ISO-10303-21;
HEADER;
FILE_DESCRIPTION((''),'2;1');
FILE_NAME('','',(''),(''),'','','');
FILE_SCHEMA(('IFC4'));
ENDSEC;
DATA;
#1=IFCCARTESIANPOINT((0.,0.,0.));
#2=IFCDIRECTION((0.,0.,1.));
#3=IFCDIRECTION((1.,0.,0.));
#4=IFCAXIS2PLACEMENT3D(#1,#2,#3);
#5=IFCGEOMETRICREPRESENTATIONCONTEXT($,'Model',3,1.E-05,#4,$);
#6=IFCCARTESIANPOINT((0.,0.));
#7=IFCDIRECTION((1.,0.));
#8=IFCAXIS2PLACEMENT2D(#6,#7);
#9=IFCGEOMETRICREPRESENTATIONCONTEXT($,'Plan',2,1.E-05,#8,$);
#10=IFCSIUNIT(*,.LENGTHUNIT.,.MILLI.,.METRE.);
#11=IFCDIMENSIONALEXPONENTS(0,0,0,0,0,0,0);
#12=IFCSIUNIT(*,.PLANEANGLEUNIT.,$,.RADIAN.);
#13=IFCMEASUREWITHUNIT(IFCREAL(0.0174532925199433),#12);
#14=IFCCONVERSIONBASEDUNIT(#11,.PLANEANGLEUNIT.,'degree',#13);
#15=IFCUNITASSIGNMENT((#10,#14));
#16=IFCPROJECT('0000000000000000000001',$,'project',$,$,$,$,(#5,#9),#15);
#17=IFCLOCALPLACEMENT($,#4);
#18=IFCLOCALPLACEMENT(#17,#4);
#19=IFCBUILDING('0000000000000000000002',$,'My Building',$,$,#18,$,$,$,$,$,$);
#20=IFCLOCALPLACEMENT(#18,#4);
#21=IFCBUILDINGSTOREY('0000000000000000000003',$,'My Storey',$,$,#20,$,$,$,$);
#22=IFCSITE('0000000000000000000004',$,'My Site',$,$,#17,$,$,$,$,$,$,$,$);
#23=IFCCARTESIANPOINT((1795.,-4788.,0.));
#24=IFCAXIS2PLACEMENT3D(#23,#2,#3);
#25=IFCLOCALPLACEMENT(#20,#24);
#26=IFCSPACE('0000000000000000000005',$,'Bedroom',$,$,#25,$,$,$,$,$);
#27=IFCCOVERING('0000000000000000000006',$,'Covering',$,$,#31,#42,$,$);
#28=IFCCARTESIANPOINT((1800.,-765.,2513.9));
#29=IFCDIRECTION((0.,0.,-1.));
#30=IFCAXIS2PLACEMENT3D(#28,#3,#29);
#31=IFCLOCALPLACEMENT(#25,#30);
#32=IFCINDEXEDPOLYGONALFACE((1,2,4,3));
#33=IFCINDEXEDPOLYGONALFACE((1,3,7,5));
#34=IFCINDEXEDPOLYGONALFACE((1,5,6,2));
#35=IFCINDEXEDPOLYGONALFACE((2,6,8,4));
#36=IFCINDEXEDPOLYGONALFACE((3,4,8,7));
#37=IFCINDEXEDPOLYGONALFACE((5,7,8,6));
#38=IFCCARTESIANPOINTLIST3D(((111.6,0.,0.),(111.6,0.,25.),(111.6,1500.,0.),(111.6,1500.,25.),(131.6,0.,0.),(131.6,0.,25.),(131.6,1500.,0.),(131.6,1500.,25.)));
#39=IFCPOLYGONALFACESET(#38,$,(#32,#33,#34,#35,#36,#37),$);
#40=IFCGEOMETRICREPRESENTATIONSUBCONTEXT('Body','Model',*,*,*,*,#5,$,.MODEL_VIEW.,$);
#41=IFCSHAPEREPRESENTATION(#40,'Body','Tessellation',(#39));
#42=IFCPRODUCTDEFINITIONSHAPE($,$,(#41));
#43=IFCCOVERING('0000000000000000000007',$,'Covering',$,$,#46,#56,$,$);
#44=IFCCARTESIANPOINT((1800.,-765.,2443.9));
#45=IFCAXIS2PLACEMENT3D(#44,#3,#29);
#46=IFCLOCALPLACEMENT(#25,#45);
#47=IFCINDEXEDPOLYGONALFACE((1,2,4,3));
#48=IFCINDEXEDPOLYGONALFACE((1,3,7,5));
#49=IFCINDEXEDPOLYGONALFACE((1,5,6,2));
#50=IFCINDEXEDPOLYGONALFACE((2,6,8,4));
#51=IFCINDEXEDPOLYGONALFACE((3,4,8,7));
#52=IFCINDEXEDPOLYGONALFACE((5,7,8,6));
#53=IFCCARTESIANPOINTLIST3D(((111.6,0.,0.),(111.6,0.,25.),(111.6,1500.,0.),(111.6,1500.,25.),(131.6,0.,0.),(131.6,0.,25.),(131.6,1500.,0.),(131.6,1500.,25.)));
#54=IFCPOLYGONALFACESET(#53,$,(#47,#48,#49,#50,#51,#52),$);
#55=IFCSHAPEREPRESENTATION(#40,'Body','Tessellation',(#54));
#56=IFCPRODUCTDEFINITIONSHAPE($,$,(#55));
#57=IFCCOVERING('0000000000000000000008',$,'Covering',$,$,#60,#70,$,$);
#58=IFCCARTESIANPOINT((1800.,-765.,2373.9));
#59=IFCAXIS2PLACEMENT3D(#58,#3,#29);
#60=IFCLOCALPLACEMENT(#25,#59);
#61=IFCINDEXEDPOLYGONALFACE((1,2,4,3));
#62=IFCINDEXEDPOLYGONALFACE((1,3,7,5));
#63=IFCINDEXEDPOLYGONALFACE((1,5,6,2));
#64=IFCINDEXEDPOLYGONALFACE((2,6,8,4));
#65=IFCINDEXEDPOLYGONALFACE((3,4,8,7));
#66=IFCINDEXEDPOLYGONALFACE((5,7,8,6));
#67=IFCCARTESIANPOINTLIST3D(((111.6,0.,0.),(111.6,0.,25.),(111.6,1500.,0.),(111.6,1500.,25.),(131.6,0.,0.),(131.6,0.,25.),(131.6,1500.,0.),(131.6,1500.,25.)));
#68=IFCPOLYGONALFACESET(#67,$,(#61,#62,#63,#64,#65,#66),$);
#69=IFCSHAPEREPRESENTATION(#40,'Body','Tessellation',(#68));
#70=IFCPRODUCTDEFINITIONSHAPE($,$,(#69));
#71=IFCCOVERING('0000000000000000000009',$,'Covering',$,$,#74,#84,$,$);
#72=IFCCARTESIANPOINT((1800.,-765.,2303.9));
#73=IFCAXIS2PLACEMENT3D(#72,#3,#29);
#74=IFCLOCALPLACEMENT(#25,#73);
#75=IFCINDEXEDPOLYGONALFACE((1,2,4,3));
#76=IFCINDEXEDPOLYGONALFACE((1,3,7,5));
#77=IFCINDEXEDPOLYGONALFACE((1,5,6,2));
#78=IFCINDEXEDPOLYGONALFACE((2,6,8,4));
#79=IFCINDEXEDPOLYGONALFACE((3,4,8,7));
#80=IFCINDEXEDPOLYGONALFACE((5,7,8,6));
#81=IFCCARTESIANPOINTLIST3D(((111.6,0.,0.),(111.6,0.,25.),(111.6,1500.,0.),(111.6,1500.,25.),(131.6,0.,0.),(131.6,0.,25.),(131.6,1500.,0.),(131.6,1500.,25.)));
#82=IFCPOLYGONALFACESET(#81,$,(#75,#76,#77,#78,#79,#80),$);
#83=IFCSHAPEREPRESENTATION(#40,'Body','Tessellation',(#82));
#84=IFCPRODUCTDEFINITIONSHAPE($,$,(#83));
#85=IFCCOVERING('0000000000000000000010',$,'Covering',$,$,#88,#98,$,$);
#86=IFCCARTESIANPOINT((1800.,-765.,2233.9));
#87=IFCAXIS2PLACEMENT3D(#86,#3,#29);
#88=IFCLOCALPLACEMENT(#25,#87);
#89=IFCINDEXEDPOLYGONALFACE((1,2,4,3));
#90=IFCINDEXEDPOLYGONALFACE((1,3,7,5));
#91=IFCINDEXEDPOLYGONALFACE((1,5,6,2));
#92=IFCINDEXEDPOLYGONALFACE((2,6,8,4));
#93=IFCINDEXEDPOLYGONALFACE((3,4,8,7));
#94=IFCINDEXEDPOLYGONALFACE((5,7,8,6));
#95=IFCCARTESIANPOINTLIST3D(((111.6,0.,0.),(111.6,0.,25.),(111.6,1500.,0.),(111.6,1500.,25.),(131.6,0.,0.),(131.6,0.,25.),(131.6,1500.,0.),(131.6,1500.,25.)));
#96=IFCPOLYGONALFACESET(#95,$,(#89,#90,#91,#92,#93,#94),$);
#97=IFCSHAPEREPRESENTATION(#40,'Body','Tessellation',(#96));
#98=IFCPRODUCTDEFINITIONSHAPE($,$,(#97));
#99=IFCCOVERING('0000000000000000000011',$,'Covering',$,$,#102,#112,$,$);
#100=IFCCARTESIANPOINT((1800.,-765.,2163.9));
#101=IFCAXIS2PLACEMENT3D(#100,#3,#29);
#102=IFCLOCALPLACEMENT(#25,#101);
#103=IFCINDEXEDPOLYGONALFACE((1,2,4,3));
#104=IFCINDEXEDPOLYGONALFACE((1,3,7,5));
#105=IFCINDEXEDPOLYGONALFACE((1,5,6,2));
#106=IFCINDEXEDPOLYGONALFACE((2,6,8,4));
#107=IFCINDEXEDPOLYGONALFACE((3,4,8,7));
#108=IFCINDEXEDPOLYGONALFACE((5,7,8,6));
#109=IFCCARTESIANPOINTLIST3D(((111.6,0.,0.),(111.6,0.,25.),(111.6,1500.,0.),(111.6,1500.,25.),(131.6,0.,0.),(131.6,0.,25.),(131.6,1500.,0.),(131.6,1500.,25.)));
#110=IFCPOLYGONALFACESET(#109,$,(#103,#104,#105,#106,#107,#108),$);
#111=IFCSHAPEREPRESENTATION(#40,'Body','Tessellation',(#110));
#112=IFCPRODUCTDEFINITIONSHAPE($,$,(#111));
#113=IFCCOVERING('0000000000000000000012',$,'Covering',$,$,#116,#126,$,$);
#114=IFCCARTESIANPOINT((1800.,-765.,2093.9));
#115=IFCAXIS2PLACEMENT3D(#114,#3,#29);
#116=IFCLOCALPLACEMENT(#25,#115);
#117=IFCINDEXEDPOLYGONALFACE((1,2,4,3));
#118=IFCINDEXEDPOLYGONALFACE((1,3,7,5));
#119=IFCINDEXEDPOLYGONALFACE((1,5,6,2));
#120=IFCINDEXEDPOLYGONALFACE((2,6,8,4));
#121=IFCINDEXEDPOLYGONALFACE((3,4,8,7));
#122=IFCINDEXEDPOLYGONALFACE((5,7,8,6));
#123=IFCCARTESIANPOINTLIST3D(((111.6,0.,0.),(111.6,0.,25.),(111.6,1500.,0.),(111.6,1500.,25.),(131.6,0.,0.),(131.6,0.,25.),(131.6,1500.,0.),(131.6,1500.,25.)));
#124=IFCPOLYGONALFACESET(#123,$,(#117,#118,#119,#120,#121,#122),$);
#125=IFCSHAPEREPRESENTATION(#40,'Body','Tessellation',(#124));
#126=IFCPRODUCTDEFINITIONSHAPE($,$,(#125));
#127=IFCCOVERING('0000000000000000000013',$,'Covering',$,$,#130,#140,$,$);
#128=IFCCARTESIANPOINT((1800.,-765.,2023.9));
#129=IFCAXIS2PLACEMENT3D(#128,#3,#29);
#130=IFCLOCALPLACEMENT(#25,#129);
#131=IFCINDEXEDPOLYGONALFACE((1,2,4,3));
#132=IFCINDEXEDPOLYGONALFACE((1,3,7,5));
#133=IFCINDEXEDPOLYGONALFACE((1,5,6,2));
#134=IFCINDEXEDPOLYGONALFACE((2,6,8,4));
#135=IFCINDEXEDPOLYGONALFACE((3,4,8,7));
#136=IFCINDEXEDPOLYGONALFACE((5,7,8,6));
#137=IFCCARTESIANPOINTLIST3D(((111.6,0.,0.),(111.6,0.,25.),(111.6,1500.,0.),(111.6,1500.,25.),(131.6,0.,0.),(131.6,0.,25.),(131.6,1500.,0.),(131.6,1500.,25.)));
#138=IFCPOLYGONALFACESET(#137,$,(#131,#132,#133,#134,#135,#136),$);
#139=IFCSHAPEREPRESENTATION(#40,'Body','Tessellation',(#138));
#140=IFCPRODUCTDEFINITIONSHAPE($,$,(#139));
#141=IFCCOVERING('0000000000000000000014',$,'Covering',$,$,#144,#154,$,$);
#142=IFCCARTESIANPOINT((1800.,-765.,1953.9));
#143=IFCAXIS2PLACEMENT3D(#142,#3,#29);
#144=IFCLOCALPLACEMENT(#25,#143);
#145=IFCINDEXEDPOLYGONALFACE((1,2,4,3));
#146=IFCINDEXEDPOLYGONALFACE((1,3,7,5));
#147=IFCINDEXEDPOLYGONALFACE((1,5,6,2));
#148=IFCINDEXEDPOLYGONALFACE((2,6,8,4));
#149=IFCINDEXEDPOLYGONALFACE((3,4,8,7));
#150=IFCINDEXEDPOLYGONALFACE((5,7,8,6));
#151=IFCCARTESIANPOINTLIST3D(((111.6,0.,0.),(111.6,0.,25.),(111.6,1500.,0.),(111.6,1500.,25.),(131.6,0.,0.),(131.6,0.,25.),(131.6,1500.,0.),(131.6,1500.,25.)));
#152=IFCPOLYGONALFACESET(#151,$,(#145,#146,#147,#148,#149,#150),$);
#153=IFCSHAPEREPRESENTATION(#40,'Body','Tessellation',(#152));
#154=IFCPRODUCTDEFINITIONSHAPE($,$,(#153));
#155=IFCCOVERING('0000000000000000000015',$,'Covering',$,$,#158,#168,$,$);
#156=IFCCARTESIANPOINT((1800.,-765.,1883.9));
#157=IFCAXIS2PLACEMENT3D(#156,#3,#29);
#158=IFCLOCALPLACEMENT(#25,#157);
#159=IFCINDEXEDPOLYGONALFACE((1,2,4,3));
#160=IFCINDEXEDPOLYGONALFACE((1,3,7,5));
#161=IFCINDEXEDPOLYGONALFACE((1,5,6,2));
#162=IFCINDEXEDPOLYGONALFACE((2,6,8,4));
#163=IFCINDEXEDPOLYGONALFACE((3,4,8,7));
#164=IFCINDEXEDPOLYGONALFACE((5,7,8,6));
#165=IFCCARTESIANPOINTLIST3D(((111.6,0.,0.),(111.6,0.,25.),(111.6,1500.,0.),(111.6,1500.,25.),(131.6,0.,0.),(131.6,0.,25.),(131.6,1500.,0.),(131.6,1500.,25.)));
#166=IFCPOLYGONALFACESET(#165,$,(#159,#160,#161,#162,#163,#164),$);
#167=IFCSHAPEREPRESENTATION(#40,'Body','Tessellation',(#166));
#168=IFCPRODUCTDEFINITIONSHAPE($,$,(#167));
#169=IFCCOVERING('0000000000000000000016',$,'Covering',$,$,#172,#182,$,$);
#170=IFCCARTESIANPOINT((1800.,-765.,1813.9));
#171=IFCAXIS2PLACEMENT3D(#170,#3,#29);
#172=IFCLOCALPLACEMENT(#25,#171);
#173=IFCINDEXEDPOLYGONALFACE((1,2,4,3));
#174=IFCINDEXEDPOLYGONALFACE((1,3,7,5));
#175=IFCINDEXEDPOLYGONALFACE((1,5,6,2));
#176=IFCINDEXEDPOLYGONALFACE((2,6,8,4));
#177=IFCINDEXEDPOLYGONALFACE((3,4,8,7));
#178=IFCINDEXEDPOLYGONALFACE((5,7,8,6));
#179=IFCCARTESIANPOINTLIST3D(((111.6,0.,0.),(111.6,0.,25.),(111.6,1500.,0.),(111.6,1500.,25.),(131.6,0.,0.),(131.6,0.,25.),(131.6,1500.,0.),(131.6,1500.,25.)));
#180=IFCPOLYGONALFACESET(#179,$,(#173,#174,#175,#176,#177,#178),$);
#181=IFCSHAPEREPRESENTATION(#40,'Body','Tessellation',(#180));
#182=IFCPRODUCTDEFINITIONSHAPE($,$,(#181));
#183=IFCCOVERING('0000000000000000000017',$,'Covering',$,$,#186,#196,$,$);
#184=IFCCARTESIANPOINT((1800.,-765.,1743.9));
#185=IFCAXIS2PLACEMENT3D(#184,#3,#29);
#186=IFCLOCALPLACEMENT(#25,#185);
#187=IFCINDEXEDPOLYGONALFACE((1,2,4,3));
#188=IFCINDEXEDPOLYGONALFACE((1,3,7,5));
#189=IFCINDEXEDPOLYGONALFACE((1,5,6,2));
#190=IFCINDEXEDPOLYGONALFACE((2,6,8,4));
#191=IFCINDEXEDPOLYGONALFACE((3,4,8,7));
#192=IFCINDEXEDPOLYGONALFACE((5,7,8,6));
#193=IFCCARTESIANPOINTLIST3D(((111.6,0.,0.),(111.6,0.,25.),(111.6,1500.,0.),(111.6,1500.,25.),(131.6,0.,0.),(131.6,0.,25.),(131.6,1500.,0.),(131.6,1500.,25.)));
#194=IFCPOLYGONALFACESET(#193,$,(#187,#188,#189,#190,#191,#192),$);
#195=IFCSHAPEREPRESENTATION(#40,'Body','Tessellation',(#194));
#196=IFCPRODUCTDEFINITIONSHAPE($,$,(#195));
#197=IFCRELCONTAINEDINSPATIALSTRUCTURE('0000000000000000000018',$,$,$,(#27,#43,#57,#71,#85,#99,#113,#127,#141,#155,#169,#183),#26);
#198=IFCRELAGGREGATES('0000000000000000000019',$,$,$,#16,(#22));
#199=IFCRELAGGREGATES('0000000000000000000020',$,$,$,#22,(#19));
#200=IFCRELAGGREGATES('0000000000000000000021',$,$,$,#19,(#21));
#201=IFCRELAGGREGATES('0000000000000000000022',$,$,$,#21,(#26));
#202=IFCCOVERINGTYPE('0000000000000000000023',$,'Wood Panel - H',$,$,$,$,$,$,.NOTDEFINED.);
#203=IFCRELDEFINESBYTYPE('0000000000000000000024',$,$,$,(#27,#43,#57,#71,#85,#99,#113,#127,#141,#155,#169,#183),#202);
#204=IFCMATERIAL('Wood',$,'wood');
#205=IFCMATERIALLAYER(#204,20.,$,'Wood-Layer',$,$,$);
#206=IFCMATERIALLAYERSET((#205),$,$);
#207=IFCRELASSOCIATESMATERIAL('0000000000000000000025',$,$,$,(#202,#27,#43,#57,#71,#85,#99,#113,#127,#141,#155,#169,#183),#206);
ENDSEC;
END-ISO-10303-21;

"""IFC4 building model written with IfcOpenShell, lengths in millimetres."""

from ifc_helpers import new_model, entity, si_unit, converted_unit, frame, origin_with_axes, origin_2d_with_axis, place, context, subcontext, project, spatial, line, indexed_curve, outline, extrude, material, layer, layer_set, layer_usage, type_object, element, save


model = new_model("IFC4")

# Units and contexts
model_context = context("Model", 3, precision=1e-05, world=origin_with_axes())
plan_context = context("Plan", 2, precision=1e-05, world=origin_2d_with_axis())
body_context_1 = subcontext(model_context, "Body", "Model", "MODEL_VIEW")
ifc_project = project(units=[si_unit("LENGTHUNIT", "METRE", prefix="MILLI"), converted_unit("PLANEANGLEUNIT", "degree", entity("IfcReal", 0.0174532925199433), si_unit("PLANEANGLEUNIT", "RADIAN"), dimensions=[0, 0, 0, 0, 0, 0, 0])], contexts=[model_context, plan_context])

# Site, building, storey
site_placement = place(None, origin_with_axes())
site = spatial("IfcSite", under=ifc_project, at=site_placement, Name="My Site")
building_placement = place(site_placement, origin_with_axes())
building = spatial("IfcBuilding", under=site, at=building_placement, Name="My Building")
storey_placement = place(building_placement, origin_with_axes())
storey = spatial("IfcBuildingStorey", under=building, at=storey_placement, Name="My Storey")

# Shared definitions
space_placement = place(storey_placement, frame((1795.0, -4788.0, 0.0), z_axis=(0.0, 0.0, 1.0), x_axis=(1.0, 0.0, 0.0)))
space = spatial("IfcSpace", under=storey, at=space_placement, Name="Bedroom")

# Coverings
ifc_material_1 = material(Name="Wood", Category="wood")
ifc_layer_1 = layer(ifc_material_1, 20.0, Name="Wood-Layer")
ifc_layer_set_1 = layer_set([ifc_layer_1])
ifc_layer_usage_1 = layer_usage(ifc_layer_set_1, "AXIS3", "POSITIVE", 0.0)
covering_type_1 = type_object("IfcCoveringType", Name="Wood Panel - H", PredefinedType="NOTDEFINED", material=ifc_layer_set_1)
covering_1_placement = place(space_placement, frame((1800.0, -765.0, 2513.9), z_axis=(1.0, 0.0, 0.0), x_axis=(0.0, 0.0, -1.0)))
element("IfcCovering", 1, at=covering_1_placement, inside=space, type_object=covering_type_1, material=ifc_layer_usage_1, Name="Covering", context=body_context_1, shape_type="SweptSolid", body=[
    extrude(outline(indexed_curve([(131.6, 1500.0), (111.6, 1500.0), (111.6, 0.0), (131.6, 0.0)], segments=[line(3, 2), line(2, 1), line(1, 4), line(4, 3)], self_intersect=False)), None, (0.0, 0.0, 1.0), 25.0),
])
ifc_layer_usage_2 = layer_usage(ifc_layer_set_1, "AXIS3", "POSITIVE", 0.0)
covering_2_placement = place(space_placement, frame((1800.0, -765.0, 2443.9), z_axis=(1.0, 0.0, 0.0), x_axis=(0.0, 0.0, -1.0)))
element("IfcCovering", 2, at=covering_2_placement, inside=space, type_object=covering_type_1, material=ifc_layer_usage_2, Name="Covering", context=body_context_1, shape_type="SweptSolid", body=[
    extrude(outline(indexed_curve([(131.6, 1500.0), (111.6, 1500.0), (111.6, 0.0), (131.6, 0.0)], segments=[line(3, 2), line(2, 1), line(1, 4), line(4, 3)], self_intersect=False)), None, (0.0, 0.0, 1.0), 25.0),
])
ifc_layer_usage_3 = layer_usage(ifc_layer_set_1, "AXIS3", "POSITIVE", 0.0)
covering_3_placement = place(space_placement, frame((1800.0, -765.0, 2373.9), z_axis=(1.0, 0.0, 0.0), x_axis=(0.0, 0.0, -1.0)))
element("IfcCovering", 3, at=covering_3_placement, inside=space, type_object=covering_type_1, material=ifc_layer_usage_3, Name="Covering", context=body_context_1, shape_type="SweptSolid", body=[
    extrude(outline(indexed_curve([(131.6, 1500.0), (111.6, 1500.0), (111.6, 0.0), (131.6, 0.0)], segments=[line(3, 2), line(2, 1), line(1, 4), line(4, 3)], self_intersect=False)), None, (0.0, 0.0, 1.0), 25.0),
])
ifc_layer_usage_4 = layer_usage(ifc_layer_set_1, "AXIS3", "POSITIVE", 0.0)
covering_4_placement = place(space_placement, frame((1800.0, -765.0, 2303.9), z_axis=(1.0, 0.0, 0.0), x_axis=(0.0, 0.0, -1.0)))
element("IfcCovering", 4, at=covering_4_placement, inside=space, type_object=covering_type_1, material=ifc_layer_usage_4, Name="Covering", context=body_context_1, shape_type="SweptSolid", body=[
    extrude(outline(indexed_curve([(131.6, 1500.0), (111.6, 1500.0), (111.6, 0.0), (131.6, 0.0)], segments=[line(3, 2), line(2, 1), line(1, 4), line(4, 3)], self_intersect=False)), None, (0.0, 0.0, 1.0), 25.0),
])
ifc_layer_usage_5 = layer_usage(ifc_layer_set_1, "AXIS3", "POSITIVE", 0.0)
covering_5_placement = place(space_placement, frame((1800.0, -765.0, 2233.9), z_axis=(1.0, 0.0, 0.0), x_axis=(0.0, 0.0, -1.0)))
element("IfcCovering", 5, at=covering_5_placement, inside=space, type_object=covering_type_1, material=ifc_layer_usage_5, Name="Covering", context=body_context_1, shape_type="SweptSolid", body=[
    extrude(outline(indexed_curve([(131.6, 1500.0), (111.6, 1500.0), (111.6, 0.0), (131.6, 0.0)], segments=[line(3, 2), line(2, 1), line(1, 4), line(4, 3)], self_intersect=False)), None, (0.0, 0.0, 1.0), 25.0),
])
ifc_layer_usage_6 = layer_usage(ifc_layer_set_1, "AXIS3", "POSITIVE", 0.0)
covering_6_placement = place(space_placement, frame((1800.0, -765.0, 2163.9), z_axis=(1.0, 0.0, 0.0), x_axis=(0.0, 0.0, -1.0)))
element("IfcCovering", 6, at=covering_6_placement, inside=space, type_object=covering_type_1, material=ifc_layer_usage_6, Name="Covering", context=body_context_1, shape_type="SweptSolid", body=[
    extrude(outline(indexed_curve([(131.6, 1500.0), (111.6, 1500.0), (111.6, 0.0), (131.6, 0.0)], segments=[line(3, 2), line(2, 1), line(1, 4), line(4, 3)], self_intersect=False)), None, (0.0, 0.0, 1.0), 25.0),
])
ifc_layer_usage_7 = layer_usage(ifc_layer_set_1, "AXIS3", "POSITIVE", 0.0)
covering_7_placement = place(space_placement, frame((1800.0, -765.0, 2093.9), z_axis=(1.0, 0.0, 0.0), x_axis=(0.0, 0.0, -1.0)))
element("IfcCovering", 7, at=covering_7_placement, inside=space, type_object=covering_type_1, material=ifc_layer_usage_7, Name="Covering", context=body_context_1, shape_type="SweptSolid", body=[
    extrude(outline(indexed_curve([(131.6, 1500.0), (111.6, 1500.0), (111.6, 0.0), (131.6, 0.0)], segments=[line(3, 2), line(2, 1), line(1, 4), line(4, 3)], self_intersect=False)), None, (0.0, 0.0, 1.0), 25.0),
])
ifc_layer_usage_8 = layer_usage(ifc_layer_set_1, "AXIS3", "POSITIVE", 0.0)
covering_8_placement = place(space_placement, frame((1800.0, -765.0, 2023.9), z_axis=(1.0, 0.0, 0.0), x_axis=(0.0, 0.0, -1.0)))
element("IfcCovering", 8, at=covering_8_placement, inside=space, type_object=covering_type_1, material=ifc_layer_usage_8, Name="Covering", context=body_context_1, shape_type="SweptSolid", body=[
    extrude(outline(indexed_curve([(131.6, 1500.0), (111.6, 1500.0), (111.6, 0.0), (131.6, 0.0)], segments=[line(3, 2), line(2, 1), line(1, 4), line(4, 3)], self_intersect=False)), None, (0.0, 0.0, 1.0), 25.0),
])
ifc_layer_usage_9 = layer_usage(ifc_layer_set_1, "AXIS3", "POSITIVE", 0.0)
covering_9_placement = place(space_placement, frame((1800.0, -765.0, 1953.9), z_axis=(1.0, 0.0, 0.0), x_axis=(0.0, 0.0, -1.0)))
element("IfcCovering", 9, at=covering_9_placement, inside=space, type_object=covering_type_1, material=ifc_layer_usage_9, Name="Covering", context=body_context_1, shape_type="SweptSolid", body=[
    extrude(outline(indexed_curve([(131.6, 1500.0), (111.6, 1500.0), (111.6, 0.0), (131.6, 0.0)], segments=[line(3, 2), line(2, 1), line(1, 4), line(4, 3)], self_intersect=False)), None, (0.0, 0.0, 1.0), 25.0),
])
ifc_layer_usage_10 = layer_usage(ifc_layer_set_1, "AXIS3", "POSITIVE", 0.0)
covering_10_placement = place(space_placement, frame((1800.0, -765.0, 1883.9), z_axis=(1.0, 0.0, 0.0), x_axis=(0.0, 0.0, -1.0)))
element("IfcCovering", 10, at=covering_10_placement, inside=space, type_object=covering_type_1, material=ifc_layer_usage_10, Name="Covering", context=body_context_1, shape_type="SweptSolid", body=[
    extrude(outline(indexed_curve([(131.6, 1500.0), (111.6, 1500.0), (111.6, 0.0), (131.6, 0.0)], segments=[line(3, 2), line(2, 1), line(1, 4), line(4, 3)], self_intersect=False)), None, (0.0, 0.0, 1.0), 25.0),
])
ifc_layer_usage_11 = layer_usage(ifc_layer_set_1, "AXIS3", "POSITIVE", 0.0)
covering_11_placement = place(space_placement, frame((1800.0, -765.0, 1813.9), z_axis=(1.0, 0.0, 0.0), x_axis=(0.0, 0.0, -1.0)))
element("IfcCovering", 11, at=covering_11_placement, inside=space, type_object=covering_type_1, material=ifc_layer_usage_11, Name="Covering", context=body_context_1, shape_type="SweptSolid", body=[
    extrude(outline(indexed_curve([(131.6, 1500.0), (111.6, 1500.0), (111.6, 0.0), (131.6, 0.0)], segments=[line(3, 2), line(2, 1), line(1, 4), line(4, 3)], self_intersect=False)), None, (0.0, 0.0, 1.0), 25.0),
])
ifc_layer_usage_12 = layer_usage(ifc_layer_set_1, "AXIS3", "POSITIVE", 0.0)
covering_12_placement = place(space_placement, frame((1800.0, -765.0, 1743.9), z_axis=(1.0, 0.0, 0.0), x_axis=(0.0, 0.0, -1.0)))
element("IfcCovering", 12, at=covering_12_placement, inside=space, type_object=covering_type_1, material=ifc_layer_usage_12, Name="Covering", context=body_context_1, shape_type="SweptSolid", body=[
    extrude(outline(indexed_curve([(131.6, 1500.0), (111.6, 1500.0), (111.6, 0.0), (131.6, 0.0)], segments=[line(3, 2), line(2, 1), line(1, 4), line(4, 3)], self_intersect=False)), None, (0.0, 0.0, 1.0), 25.0),
])

save(model, "model.ifc")
